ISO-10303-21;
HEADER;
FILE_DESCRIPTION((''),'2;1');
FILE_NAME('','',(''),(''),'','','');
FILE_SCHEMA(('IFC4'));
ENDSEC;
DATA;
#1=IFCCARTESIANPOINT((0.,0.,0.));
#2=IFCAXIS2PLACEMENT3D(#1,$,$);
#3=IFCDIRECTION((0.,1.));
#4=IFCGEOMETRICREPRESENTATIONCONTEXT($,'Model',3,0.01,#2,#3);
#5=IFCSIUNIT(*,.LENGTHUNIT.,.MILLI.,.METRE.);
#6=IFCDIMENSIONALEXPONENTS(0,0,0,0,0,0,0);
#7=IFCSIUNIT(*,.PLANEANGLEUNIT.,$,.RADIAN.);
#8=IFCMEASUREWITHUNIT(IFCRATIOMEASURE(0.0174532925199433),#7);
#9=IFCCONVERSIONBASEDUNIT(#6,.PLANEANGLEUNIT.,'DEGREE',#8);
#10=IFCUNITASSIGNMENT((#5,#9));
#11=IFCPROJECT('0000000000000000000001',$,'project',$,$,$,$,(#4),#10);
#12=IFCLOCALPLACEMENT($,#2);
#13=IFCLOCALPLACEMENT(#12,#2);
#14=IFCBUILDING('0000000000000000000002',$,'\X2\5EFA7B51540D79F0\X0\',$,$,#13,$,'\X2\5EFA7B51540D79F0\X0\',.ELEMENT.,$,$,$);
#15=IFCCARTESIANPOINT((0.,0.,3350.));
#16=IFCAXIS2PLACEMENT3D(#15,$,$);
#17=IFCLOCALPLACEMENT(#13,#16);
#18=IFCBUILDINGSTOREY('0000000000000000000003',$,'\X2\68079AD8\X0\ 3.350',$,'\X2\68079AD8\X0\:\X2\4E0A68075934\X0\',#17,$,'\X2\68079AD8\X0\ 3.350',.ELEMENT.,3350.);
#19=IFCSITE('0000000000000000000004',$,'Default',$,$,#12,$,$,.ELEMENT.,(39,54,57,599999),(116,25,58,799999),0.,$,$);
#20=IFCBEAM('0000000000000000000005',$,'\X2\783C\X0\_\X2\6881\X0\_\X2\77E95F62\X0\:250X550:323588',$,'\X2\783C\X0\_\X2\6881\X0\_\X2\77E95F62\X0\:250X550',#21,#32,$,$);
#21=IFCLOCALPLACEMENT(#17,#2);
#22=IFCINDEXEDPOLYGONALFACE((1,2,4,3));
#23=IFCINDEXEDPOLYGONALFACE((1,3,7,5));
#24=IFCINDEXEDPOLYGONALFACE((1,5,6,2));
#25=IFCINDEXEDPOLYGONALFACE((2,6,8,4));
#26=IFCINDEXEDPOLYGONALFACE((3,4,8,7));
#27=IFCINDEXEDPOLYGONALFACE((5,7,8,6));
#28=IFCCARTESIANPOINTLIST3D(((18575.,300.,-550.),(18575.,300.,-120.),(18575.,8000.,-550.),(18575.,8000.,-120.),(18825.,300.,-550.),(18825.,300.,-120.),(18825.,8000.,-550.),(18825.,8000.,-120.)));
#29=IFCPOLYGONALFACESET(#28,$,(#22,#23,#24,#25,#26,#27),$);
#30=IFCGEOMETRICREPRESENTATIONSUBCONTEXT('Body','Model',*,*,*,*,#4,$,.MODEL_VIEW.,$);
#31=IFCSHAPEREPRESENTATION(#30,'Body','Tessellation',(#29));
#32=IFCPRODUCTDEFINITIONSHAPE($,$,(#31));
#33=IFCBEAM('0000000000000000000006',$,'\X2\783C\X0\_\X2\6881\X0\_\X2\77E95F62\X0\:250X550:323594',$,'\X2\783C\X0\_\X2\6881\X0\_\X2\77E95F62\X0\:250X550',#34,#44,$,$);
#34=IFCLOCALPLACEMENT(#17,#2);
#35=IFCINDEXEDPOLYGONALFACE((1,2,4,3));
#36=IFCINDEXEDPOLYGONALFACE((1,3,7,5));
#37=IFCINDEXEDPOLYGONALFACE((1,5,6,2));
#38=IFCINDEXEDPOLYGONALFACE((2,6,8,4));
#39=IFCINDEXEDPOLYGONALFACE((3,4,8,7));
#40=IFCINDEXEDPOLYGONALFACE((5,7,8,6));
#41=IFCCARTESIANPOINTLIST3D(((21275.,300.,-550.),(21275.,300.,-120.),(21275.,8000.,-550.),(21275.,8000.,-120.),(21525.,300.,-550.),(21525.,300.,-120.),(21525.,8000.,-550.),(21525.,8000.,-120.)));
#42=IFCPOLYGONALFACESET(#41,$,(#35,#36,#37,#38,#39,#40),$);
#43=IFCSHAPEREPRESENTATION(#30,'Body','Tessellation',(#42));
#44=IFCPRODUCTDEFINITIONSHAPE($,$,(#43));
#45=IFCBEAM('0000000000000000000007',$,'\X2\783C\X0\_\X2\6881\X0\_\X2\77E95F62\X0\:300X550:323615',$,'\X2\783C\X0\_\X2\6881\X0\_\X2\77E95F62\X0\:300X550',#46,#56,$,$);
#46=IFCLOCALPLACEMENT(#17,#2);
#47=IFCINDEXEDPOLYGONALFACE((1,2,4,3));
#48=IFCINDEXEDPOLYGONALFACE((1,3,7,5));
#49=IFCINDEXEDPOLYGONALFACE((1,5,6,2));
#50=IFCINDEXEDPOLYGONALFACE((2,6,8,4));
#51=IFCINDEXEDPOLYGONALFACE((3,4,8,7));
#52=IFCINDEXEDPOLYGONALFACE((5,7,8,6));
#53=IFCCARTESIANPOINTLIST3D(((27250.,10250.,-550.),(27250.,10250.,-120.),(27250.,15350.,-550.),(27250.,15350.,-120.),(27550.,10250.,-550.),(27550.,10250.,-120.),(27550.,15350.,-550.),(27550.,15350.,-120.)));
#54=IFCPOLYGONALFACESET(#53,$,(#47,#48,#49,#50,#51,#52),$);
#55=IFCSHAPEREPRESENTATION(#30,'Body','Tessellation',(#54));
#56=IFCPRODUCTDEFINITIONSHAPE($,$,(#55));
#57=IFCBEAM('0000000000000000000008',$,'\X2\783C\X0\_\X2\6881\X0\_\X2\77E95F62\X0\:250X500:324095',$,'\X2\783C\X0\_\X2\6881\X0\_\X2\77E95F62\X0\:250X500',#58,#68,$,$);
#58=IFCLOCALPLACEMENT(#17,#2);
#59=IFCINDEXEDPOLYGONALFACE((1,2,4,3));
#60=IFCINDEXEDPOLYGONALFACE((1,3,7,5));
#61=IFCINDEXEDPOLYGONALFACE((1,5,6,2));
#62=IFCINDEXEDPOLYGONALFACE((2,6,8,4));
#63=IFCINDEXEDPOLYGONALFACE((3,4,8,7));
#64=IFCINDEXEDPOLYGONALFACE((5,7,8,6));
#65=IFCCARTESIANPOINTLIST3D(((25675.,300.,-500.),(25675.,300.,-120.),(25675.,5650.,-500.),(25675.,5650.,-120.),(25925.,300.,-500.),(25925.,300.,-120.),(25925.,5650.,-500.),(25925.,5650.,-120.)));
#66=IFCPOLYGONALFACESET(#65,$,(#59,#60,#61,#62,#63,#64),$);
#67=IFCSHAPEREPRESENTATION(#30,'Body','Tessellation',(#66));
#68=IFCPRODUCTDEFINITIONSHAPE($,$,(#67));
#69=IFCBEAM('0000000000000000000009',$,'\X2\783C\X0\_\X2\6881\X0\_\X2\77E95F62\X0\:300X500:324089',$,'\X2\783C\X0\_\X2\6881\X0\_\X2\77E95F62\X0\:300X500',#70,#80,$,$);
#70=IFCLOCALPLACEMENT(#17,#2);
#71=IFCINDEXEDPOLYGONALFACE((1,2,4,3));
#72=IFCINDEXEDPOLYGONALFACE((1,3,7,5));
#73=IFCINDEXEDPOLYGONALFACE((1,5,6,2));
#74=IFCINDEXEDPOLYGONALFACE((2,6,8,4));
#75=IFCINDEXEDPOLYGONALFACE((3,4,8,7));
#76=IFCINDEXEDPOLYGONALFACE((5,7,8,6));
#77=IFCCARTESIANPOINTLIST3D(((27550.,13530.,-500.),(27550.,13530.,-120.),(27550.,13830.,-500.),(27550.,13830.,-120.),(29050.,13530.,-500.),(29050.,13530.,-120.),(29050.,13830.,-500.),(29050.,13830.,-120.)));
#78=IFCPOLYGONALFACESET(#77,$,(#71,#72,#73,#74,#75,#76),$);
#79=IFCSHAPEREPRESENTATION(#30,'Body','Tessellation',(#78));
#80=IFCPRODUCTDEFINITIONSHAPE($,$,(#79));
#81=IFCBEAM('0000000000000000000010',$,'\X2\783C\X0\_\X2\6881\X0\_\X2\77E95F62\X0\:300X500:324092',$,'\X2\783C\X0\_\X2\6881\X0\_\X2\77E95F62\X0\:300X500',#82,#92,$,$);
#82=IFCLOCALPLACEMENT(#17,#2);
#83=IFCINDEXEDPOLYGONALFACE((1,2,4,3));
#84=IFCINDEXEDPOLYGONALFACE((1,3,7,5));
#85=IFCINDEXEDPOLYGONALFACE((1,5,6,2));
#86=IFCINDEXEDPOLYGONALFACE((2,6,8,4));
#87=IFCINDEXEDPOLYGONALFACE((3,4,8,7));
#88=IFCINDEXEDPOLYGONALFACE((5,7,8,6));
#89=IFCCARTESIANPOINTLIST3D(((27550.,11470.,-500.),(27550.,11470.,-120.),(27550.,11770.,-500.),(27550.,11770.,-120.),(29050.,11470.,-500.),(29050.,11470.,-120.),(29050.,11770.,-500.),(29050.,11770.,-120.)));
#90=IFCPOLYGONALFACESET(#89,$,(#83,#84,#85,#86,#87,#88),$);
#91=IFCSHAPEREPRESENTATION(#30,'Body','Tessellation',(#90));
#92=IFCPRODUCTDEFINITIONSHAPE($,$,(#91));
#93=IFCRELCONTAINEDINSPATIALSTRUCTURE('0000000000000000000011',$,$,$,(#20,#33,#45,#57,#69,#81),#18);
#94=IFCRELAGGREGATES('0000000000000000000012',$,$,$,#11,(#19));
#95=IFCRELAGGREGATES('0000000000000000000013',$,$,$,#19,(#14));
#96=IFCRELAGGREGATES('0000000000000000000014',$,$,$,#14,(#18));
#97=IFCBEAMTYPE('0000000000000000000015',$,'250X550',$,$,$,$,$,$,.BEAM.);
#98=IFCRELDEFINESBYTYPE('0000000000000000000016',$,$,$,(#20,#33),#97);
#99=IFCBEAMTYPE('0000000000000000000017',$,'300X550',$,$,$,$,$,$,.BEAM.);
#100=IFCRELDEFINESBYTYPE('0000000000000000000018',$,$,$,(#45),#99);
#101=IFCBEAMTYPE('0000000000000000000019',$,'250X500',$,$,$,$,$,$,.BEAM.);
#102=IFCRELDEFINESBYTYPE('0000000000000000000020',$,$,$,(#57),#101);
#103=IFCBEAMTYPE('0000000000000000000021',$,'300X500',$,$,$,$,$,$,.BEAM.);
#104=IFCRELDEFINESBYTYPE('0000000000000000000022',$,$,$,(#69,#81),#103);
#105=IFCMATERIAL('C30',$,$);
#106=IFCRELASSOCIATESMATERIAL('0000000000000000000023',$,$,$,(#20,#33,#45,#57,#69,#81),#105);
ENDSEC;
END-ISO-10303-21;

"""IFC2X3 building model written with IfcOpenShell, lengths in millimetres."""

from ifc_helpers import new_model, entity, si_unit, converted_unit, direction, frame, frame_2d, origin, origin_2d_with_axis, place, context, subcontext, project, spatial, rectangle, extrude, material, type_object, element, save


model = new_model("IFC2X3")

# Units and contexts
model_context = context("Model", 3, precision=0.01, world=origin(), true_north=direction((0.0, 1.0)))
body_context = subcontext(model_context, "Body", "Model", "MODEL_VIEW")
ifc_project = project(units=[si_unit("LENGTHUNIT", "METRE", prefix="MILLI"), converted_unit("PLANEANGLEUNIT", "DEGREE", entity("IfcRatioMeasure", 0.0174532925199433), si_unit("PLANEANGLEUNIT", "RADIAN"), dimensions=[0, 0, 0, 0, 0, 0, 0])], contexts=[model_context])

# Site, building, storey
site_placement = place(None, origin())
site = spatial("IfcSite", under=ifc_project, at=site_placement, Name="Default", CompositionType="ELEMENT", RefLatitude=(39, 54, 57, 599999), RefLongitude=(116, 25, 58, 799999), RefElevation=0.0)
building_placement = place(site_placement, origin())
building = spatial("IfcBuilding", under=site, at=building_placement, Name="建筑名称", LongName="建筑名称", CompositionType="ELEMENT")
storey_placement = place(building_placement, frame((0.0, 0.0, 3350.0)))
storey = spatial("IfcBuildingStorey", under=building, at=storey_placement, Name="标高 3.350", ObjectType="标高:上标头", LongName="标高 3.350", CompositionType="ELEMENT", Elevation=3350.0)

# Beams
ifc_material_1 = material(Name="C30")
beam_type_1 = type_object("IfcBeamType", Name="250X550", PredefinedType="BEAM")
for number, where, z_axis, x_axis, name in (
    (1, (18700.0, 0.0, 0.0), (0.0, 0.0, 1.0), (0.0, 1.0, 0.0), "砼_梁_矩形:250X550:323588"),
    (2, (21400.0, 0.0, 0.0), (0.0, 0.0, 1.0), (0.0, 1.0, 0.0), "砼_梁_矩形:250X550:323594"),
):
    element("IfcBeam", number, at=place(storey_placement, frame(where, z_axis=z_axis, x_axis=x_axis)), inside=storey, type_object=beam_type_1, material=ifc_material_1, Name=name, ObjectType="砼_梁_矩形:250X550", context=body_context, shape_type="SweptSolid", body=[
        extrude(rectangle(XDim=430.0, YDim=250.0, at=origin_2d_with_axis()), frame((300.0, 0.0, -335.0), z_axis=(1.0, 0.0, 0.0), x_axis=(0.0, 0.0, -1.0)), (0.0, 0.0, 1.0), 7700.0),
    ])
beam_type_2 = type_object("IfcBeamType", Name="300X550", PredefinedType="BEAM")
beam_1_placement = place(storey_placement, frame((27250.0, 9950.0, 0.0), z_axis=(0.0, 0.0, 1.0), x_axis=(0.0, 1.0, 0.0)))
element("IfcBeam", 3, at=beam_1_placement, inside=storey, type_object=beam_type_2, material=ifc_material_1, Name="砼_梁_矩形:300X550:323615", ObjectType="砼_梁_矩形:300X550", context=body_context, shape_type="SweptSolid", body=[
    extrude(rectangle(XDim=430.0, YDim=300.0, at=frame_2d((0.0, 0.0), x_axis=(1.0, 0.0))), frame((300.0, -150.0, -335.0), z_axis=(1.0, 0.0, 0.0), x_axis=(0.0, 0.0, -1.0)), (0.0, 0.0, 1.0), 5100.0),
])
beam_type_3 = type_object("IfcBeamType", Name="250X500", PredefinedType="BEAM")
beam_2_placement = place(storey_placement, frame((25800.0, 0.0, 0.0), z_axis=(0.0, 0.0, 1.0), x_axis=(0.0, 1.0, 0.0)))
element("IfcBeam", 4, at=beam_2_placement, inside=storey, type_object=beam_type_3, material=ifc_material_1, Name="砼_梁_矩形:250X500:324095", ObjectType="砼_梁_矩形:250X500", context=body_context, shape_type="SweptSolid", body=[
    extrude(rectangle(XDim=380.0, YDim=250.0, at=frame_2d((0.0, 0.0), x_axis=(1.0, 0.0))), frame((300.0, 0.0, -310.0), z_axis=(1.0, 0.0, 0.0), x_axis=(0.0, 0.0, -1.0)), (0.0, 0.0, 1.0), 5350.0),
])
beam_type_4 = type_object("IfcBeamType", Name="300X500", PredefinedType="BEAM")
for number, where, name in (
    (5, (27250.0, 13680.0, 0.0), "砼_梁_矩形:300X500:324089"),
    (6, (27250.0, 11620.0, 0.0), "砼_梁_矩形:300X500:324092"),
):
    element("IfcBeam", number, at=place(storey_placement, frame(where)), inside=storey, type_object=beam_type_4, material=ifc_material_1, Name=name, ObjectType="砼_梁_矩形:300X500", context=body_context, shape_type="SweptSolid", body=[
        extrude(rectangle(XDim=380.0, YDim=300.0, at=frame_2d((0.0, 0.0), x_axis=(1.0, 0.0))), frame((300.0, 0.0, -310.0), z_axis=(1.0, 0.0, 0.0), x_axis=(0.0, 0.0, -1.0)), (0.0, 0.0, 1.0), 1500.0),
    ])

save(model, "model.ifc")
